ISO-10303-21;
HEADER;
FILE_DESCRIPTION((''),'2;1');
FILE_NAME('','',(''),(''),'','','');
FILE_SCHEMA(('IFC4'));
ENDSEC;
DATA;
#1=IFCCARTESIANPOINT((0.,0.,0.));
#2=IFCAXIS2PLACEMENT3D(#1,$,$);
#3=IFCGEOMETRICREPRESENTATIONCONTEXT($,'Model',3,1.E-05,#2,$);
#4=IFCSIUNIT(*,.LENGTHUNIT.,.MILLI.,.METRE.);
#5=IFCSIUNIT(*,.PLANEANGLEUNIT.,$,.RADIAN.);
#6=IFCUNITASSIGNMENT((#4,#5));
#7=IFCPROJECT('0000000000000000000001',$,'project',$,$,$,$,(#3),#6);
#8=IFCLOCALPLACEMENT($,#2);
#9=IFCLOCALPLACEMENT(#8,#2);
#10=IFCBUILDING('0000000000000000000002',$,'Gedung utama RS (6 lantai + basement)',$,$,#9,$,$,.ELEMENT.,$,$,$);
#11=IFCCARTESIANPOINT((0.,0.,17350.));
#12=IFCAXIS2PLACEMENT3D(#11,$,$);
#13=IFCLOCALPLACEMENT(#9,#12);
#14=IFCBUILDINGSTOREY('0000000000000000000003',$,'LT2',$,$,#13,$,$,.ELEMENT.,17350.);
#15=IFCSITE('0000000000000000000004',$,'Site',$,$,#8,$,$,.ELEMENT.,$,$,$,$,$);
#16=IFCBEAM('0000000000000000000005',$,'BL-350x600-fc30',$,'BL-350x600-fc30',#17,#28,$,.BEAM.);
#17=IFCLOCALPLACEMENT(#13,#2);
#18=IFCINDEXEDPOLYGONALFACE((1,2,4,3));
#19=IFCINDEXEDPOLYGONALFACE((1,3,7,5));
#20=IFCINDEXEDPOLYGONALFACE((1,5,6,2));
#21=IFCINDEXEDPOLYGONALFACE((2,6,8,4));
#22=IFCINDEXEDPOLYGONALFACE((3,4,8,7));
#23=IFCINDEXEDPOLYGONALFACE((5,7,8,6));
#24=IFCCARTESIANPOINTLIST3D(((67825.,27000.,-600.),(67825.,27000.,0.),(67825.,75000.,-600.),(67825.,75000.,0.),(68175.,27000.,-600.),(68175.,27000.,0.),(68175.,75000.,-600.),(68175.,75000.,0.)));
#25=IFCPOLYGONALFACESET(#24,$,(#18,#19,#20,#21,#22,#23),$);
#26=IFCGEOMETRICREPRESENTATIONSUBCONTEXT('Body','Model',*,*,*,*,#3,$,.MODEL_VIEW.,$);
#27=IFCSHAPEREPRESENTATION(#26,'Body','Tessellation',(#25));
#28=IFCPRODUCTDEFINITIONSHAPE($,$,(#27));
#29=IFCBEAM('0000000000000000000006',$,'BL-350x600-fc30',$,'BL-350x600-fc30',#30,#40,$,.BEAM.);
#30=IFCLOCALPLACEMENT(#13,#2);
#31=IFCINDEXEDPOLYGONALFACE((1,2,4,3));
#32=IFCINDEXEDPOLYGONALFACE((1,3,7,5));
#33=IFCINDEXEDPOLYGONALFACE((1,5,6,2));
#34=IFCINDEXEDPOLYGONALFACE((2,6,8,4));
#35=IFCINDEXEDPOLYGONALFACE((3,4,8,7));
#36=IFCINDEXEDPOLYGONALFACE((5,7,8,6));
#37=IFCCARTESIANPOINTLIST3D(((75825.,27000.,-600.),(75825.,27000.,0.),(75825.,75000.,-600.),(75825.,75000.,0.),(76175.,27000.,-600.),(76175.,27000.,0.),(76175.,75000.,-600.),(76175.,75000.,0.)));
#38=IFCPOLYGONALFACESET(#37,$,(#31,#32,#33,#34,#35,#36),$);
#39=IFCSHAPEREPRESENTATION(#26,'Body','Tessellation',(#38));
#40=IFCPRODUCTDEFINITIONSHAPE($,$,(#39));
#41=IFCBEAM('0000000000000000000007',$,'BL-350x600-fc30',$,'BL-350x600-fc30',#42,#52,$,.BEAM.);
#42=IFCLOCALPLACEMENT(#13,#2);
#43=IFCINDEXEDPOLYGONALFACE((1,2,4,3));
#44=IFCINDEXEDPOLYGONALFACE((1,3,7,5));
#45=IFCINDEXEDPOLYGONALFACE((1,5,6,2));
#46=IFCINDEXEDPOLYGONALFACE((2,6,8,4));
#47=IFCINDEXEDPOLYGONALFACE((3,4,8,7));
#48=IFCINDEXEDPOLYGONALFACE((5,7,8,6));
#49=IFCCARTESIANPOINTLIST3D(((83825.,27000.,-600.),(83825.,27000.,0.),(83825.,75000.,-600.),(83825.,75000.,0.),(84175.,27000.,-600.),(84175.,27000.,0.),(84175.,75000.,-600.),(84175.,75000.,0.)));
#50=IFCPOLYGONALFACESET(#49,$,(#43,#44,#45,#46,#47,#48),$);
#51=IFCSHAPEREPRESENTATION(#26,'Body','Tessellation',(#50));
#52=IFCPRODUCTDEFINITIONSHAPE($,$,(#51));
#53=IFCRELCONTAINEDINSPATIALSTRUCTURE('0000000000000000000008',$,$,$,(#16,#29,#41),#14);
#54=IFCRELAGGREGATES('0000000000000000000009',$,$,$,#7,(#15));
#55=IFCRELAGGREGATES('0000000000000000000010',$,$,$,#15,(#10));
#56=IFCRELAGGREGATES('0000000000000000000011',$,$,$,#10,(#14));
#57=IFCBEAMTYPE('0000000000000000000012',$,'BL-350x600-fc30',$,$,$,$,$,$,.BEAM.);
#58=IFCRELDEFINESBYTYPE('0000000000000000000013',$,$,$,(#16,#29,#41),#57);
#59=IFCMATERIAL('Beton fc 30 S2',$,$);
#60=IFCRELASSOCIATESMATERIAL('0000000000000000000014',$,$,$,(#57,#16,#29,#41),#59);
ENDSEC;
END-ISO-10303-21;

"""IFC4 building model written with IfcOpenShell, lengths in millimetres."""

from ifc_helpers import new_model, si_unit, frame, origin, origin_2d, place, context, subcontext, project, spatial, rectangle, extrude, material, material_profile, profile_set, profile_usage, type_object, element, save


model = new_model("IFC4")

# Units and contexts
model_context = context("Model", 3, precision=1e-05, world=origin())
body_context = subcontext(model_context, "Body", "Model", "MODEL_VIEW")
ifc_project = project(units=[si_unit("LENGTHUNIT", "METRE", prefix="MILLI"), si_unit("PLANEANGLEUNIT", "RADIAN")], contexts=[model_context])

# Site, building, storey
site_placement = place(None, origin())
site = spatial("IfcSite", under=ifc_project, at=site_placement, Name="Site", CompositionType="ELEMENT")
building_placement = place(site_placement, origin())
building = spatial("IfcBuilding", under=site, at=building_placement, Name="Gedung utama RS (6 lantai + basement)", CompositionType="ELEMENT")
storey_placement = place(building_placement, frame((0.0, 0.0, 17350.0)))
storey = spatial("IfcBuildingStorey", under=building, at=storey_placement, Name="LT2", CompositionType="ELEMENT", Elevation=17350.0)

# Beams
ifc_material = material(Name="Beton fc 30 S2")
ifc_material_profile_1 = material_profile(ifc_material, rectangle(XDim=350.0, YDim=600.0, at=origin_2d()), Name="BL-350x600-fc30")
ifc_profile_set_1 = profile_set([ifc_material_profile_1], Name="BL-350x600-fc30")
ifc_profile_usage_1 = profile_usage(ifc_profile_set_1, cardinal=8)
beam_type = type_object("IfcBeamType", Name="BL-350x600-fc30", PredefinedType="BEAM", material=ifc_profile_set_1)
for number, where, name in (
    (1, (68000.0, 27000.0, -300.0), "BL-350x600-fc30"),
    (2, (76000.0, 27000.0, -300.0), "BL-350x600-fc30"),
    (3, (84000.0, 27000.0, -300.0), "BL-350x600-fc30"),
):
    element("IfcBeam", number, at=place(storey_placement, frame(where)), inside=storey, type_object=beam_type, material=ifc_profile_usage_1, Name=name, ObjectType="BL-350x600-fc30", PredefinedType="BEAM", context=body_context, shape_type="SweptSolid", body=[
        extrude(rectangle(XDim=350.0, YDim=600.0, at=origin_2d()), frame((0.0, 0.0, 0.0), z_axis=(0.0, 1.0, 0.0), x_axis=(-1.0, 0.0, 0.0)), (0.0, 0.0, 1.0), 48000.0),
    ])

save(model, "model.ifc")
